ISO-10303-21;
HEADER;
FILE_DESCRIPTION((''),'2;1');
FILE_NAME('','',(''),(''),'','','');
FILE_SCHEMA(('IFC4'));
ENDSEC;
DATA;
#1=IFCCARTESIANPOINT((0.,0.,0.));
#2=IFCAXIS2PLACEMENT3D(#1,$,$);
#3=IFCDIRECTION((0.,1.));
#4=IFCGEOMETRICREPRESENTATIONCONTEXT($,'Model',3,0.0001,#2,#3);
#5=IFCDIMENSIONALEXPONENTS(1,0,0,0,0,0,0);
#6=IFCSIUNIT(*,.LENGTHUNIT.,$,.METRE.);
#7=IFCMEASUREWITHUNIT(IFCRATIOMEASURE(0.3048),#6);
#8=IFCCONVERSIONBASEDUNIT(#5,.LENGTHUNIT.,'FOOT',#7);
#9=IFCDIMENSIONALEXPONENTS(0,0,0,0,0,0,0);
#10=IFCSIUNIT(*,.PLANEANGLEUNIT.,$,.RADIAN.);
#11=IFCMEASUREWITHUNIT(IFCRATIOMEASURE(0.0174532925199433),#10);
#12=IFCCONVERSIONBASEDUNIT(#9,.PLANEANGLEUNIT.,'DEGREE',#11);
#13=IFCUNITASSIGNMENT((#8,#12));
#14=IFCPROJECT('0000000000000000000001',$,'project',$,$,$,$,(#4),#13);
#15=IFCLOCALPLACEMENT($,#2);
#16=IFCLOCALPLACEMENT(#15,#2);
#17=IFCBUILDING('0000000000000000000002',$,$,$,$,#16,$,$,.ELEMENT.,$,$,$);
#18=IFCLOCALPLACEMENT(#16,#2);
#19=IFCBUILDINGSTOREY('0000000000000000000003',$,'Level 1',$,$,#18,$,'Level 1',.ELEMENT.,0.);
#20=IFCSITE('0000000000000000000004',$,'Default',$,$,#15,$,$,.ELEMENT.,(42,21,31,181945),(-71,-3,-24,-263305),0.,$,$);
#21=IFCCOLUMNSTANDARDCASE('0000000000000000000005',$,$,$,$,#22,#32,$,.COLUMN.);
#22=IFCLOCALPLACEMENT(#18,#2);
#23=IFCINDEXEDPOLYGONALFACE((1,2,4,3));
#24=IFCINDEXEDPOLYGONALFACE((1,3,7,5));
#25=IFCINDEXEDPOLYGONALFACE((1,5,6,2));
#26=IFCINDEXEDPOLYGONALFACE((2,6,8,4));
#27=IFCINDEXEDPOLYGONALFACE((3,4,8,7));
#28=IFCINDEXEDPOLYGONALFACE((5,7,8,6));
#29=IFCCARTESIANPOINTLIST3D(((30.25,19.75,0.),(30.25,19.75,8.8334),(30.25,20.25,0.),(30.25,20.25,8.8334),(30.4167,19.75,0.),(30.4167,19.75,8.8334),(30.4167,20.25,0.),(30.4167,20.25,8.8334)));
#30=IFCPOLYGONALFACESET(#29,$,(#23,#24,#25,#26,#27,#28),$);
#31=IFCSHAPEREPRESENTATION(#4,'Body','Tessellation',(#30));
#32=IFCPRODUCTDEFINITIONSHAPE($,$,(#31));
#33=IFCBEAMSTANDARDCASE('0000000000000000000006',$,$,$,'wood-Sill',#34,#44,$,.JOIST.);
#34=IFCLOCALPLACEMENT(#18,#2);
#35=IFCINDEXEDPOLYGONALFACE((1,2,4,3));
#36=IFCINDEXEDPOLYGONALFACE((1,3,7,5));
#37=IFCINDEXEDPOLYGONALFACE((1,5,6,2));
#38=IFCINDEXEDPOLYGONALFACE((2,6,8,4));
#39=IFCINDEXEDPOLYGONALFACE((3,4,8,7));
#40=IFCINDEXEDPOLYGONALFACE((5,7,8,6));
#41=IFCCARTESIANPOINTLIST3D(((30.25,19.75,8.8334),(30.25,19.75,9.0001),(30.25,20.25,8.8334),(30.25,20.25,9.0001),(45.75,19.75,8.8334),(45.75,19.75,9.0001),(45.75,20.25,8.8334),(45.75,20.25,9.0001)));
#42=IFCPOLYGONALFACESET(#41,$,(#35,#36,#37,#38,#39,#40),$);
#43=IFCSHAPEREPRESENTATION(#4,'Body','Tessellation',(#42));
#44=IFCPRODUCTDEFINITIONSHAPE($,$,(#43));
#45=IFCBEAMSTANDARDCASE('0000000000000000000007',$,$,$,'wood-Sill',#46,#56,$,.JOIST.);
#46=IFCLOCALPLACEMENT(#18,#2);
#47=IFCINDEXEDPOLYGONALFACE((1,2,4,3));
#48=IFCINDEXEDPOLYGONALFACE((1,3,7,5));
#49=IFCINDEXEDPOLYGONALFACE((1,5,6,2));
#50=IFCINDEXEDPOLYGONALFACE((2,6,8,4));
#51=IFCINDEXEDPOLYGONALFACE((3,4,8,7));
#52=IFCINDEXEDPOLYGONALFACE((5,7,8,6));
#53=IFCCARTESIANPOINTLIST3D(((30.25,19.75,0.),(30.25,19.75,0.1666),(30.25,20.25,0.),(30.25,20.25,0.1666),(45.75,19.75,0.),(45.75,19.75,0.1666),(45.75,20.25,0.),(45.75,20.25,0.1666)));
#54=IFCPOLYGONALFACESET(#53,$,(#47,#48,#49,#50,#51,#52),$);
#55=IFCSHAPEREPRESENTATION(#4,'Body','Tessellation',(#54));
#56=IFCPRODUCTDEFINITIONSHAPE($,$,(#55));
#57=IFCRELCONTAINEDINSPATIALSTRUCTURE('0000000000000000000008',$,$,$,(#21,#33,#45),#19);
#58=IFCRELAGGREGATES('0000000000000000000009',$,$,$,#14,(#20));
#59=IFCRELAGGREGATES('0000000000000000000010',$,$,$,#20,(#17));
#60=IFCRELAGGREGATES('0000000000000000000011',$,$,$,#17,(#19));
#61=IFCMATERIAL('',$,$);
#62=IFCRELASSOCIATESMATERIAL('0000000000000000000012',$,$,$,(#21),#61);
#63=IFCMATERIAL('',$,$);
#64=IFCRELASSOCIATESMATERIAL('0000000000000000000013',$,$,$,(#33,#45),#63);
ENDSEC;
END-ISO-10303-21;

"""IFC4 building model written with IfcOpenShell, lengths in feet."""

from ifc_helpers import new_model, entity, si_unit, converted_unit, direction, frame, origin, origin_with_axes, place, context, project, spatial, rectangle, extrude, material, element, save


model = new_model("IFC4")

# Units and contexts
model_context = context("Model", 3, precision=0.0001, world=origin(), true_north=direction((0.0, 1.0)))
ifc_project = project(units=[converted_unit("LENGTHUNIT", "FOOT", entity("IfcRatioMeasure", 0.3048), si_unit("LENGTHUNIT", "METRE"), dimensions=[1, 0, 0, 0, 0, 0, 0]), converted_unit("PLANEANGLEUNIT", "DEGREE", entity("IfcRatioMeasure", 0.0174532925199433), si_unit("PLANEANGLEUNIT", "RADIAN"), dimensions=[0, 0, 0, 0, 0, 0, 0])], contexts=[model_context])

# Site, building, storey
site_placement = place(None, origin())
site = spatial("IfcSite", under=ifc_project, at=site_placement, Name="Default", CompositionType="ELEMENT", RefLatitude=(42, 21, 31, 181945), RefLongitude=(-71, -3, -24, -263305), RefElevation=0.0)
building_placement = place(site_placement, origin())
building = spatial("IfcBuilding", under=site, at=building_placement, CompositionType="ELEMENT")
storey_placement = place(building_placement, origin())
storey = spatial("IfcBuildingStorey", under=building, at=storey_placement, Name="Level 1", LongName="Level 1", CompositionType="ELEMENT", Elevation=0.0)

# Column
ifc_material_1 = material(Name="")
placement_1 = place(storey_placement, frame((30.25, 20.0, 0.0)))
for number, where, z_axis, x_axis in (
    (1, (0.0833, 0.0, 0.0), (0.0, 0.0, 1.0), (1.0, 0.0, 0.0)),
):
    element("IfcColumnStandardCase", number, at=place(placement_1, frame(where, z_axis=z_axis, x_axis=x_axis)), inside=storey, material=ifc_material_1, PredefinedType="COLUMN", context=model_context, shape_type="SweptSolid", body=[
        extrude(rectangle(XDim=0.1667, YDim=0.5), origin(), (0.0, 0.0, 1.0), 8.8334),
    ])

# Beams
ifc_material_2 = material(Name="")
for number, where, z_axis, x_axis in (
    (2, (0.0, 0.0, 8.9167), (1.0, 0.0, 0.0), (0.0, 0.0, 1.0)),
    (3, (0.0, 0.0, 0.0833), (1.0, 0.0, 0.0), (0.0, 0.0, 1.0)),
):
    element("IfcBeamStandardCase", number, at=place(placement_1, frame(where, z_axis=z_axis, x_axis=x_axis)), inside=storey, material=ifc_material_2, ObjectType="wood-Sill", PredefinedType="JOIST", context=model_context, shape_type="SweptSolid", body=[
        extrude(rectangle(XDim=0.1667, YDim=0.5), origin_with_axes(), (0.0, 0.0, 1.0), 15.5),
    ])

save(model, "model.ifc")
